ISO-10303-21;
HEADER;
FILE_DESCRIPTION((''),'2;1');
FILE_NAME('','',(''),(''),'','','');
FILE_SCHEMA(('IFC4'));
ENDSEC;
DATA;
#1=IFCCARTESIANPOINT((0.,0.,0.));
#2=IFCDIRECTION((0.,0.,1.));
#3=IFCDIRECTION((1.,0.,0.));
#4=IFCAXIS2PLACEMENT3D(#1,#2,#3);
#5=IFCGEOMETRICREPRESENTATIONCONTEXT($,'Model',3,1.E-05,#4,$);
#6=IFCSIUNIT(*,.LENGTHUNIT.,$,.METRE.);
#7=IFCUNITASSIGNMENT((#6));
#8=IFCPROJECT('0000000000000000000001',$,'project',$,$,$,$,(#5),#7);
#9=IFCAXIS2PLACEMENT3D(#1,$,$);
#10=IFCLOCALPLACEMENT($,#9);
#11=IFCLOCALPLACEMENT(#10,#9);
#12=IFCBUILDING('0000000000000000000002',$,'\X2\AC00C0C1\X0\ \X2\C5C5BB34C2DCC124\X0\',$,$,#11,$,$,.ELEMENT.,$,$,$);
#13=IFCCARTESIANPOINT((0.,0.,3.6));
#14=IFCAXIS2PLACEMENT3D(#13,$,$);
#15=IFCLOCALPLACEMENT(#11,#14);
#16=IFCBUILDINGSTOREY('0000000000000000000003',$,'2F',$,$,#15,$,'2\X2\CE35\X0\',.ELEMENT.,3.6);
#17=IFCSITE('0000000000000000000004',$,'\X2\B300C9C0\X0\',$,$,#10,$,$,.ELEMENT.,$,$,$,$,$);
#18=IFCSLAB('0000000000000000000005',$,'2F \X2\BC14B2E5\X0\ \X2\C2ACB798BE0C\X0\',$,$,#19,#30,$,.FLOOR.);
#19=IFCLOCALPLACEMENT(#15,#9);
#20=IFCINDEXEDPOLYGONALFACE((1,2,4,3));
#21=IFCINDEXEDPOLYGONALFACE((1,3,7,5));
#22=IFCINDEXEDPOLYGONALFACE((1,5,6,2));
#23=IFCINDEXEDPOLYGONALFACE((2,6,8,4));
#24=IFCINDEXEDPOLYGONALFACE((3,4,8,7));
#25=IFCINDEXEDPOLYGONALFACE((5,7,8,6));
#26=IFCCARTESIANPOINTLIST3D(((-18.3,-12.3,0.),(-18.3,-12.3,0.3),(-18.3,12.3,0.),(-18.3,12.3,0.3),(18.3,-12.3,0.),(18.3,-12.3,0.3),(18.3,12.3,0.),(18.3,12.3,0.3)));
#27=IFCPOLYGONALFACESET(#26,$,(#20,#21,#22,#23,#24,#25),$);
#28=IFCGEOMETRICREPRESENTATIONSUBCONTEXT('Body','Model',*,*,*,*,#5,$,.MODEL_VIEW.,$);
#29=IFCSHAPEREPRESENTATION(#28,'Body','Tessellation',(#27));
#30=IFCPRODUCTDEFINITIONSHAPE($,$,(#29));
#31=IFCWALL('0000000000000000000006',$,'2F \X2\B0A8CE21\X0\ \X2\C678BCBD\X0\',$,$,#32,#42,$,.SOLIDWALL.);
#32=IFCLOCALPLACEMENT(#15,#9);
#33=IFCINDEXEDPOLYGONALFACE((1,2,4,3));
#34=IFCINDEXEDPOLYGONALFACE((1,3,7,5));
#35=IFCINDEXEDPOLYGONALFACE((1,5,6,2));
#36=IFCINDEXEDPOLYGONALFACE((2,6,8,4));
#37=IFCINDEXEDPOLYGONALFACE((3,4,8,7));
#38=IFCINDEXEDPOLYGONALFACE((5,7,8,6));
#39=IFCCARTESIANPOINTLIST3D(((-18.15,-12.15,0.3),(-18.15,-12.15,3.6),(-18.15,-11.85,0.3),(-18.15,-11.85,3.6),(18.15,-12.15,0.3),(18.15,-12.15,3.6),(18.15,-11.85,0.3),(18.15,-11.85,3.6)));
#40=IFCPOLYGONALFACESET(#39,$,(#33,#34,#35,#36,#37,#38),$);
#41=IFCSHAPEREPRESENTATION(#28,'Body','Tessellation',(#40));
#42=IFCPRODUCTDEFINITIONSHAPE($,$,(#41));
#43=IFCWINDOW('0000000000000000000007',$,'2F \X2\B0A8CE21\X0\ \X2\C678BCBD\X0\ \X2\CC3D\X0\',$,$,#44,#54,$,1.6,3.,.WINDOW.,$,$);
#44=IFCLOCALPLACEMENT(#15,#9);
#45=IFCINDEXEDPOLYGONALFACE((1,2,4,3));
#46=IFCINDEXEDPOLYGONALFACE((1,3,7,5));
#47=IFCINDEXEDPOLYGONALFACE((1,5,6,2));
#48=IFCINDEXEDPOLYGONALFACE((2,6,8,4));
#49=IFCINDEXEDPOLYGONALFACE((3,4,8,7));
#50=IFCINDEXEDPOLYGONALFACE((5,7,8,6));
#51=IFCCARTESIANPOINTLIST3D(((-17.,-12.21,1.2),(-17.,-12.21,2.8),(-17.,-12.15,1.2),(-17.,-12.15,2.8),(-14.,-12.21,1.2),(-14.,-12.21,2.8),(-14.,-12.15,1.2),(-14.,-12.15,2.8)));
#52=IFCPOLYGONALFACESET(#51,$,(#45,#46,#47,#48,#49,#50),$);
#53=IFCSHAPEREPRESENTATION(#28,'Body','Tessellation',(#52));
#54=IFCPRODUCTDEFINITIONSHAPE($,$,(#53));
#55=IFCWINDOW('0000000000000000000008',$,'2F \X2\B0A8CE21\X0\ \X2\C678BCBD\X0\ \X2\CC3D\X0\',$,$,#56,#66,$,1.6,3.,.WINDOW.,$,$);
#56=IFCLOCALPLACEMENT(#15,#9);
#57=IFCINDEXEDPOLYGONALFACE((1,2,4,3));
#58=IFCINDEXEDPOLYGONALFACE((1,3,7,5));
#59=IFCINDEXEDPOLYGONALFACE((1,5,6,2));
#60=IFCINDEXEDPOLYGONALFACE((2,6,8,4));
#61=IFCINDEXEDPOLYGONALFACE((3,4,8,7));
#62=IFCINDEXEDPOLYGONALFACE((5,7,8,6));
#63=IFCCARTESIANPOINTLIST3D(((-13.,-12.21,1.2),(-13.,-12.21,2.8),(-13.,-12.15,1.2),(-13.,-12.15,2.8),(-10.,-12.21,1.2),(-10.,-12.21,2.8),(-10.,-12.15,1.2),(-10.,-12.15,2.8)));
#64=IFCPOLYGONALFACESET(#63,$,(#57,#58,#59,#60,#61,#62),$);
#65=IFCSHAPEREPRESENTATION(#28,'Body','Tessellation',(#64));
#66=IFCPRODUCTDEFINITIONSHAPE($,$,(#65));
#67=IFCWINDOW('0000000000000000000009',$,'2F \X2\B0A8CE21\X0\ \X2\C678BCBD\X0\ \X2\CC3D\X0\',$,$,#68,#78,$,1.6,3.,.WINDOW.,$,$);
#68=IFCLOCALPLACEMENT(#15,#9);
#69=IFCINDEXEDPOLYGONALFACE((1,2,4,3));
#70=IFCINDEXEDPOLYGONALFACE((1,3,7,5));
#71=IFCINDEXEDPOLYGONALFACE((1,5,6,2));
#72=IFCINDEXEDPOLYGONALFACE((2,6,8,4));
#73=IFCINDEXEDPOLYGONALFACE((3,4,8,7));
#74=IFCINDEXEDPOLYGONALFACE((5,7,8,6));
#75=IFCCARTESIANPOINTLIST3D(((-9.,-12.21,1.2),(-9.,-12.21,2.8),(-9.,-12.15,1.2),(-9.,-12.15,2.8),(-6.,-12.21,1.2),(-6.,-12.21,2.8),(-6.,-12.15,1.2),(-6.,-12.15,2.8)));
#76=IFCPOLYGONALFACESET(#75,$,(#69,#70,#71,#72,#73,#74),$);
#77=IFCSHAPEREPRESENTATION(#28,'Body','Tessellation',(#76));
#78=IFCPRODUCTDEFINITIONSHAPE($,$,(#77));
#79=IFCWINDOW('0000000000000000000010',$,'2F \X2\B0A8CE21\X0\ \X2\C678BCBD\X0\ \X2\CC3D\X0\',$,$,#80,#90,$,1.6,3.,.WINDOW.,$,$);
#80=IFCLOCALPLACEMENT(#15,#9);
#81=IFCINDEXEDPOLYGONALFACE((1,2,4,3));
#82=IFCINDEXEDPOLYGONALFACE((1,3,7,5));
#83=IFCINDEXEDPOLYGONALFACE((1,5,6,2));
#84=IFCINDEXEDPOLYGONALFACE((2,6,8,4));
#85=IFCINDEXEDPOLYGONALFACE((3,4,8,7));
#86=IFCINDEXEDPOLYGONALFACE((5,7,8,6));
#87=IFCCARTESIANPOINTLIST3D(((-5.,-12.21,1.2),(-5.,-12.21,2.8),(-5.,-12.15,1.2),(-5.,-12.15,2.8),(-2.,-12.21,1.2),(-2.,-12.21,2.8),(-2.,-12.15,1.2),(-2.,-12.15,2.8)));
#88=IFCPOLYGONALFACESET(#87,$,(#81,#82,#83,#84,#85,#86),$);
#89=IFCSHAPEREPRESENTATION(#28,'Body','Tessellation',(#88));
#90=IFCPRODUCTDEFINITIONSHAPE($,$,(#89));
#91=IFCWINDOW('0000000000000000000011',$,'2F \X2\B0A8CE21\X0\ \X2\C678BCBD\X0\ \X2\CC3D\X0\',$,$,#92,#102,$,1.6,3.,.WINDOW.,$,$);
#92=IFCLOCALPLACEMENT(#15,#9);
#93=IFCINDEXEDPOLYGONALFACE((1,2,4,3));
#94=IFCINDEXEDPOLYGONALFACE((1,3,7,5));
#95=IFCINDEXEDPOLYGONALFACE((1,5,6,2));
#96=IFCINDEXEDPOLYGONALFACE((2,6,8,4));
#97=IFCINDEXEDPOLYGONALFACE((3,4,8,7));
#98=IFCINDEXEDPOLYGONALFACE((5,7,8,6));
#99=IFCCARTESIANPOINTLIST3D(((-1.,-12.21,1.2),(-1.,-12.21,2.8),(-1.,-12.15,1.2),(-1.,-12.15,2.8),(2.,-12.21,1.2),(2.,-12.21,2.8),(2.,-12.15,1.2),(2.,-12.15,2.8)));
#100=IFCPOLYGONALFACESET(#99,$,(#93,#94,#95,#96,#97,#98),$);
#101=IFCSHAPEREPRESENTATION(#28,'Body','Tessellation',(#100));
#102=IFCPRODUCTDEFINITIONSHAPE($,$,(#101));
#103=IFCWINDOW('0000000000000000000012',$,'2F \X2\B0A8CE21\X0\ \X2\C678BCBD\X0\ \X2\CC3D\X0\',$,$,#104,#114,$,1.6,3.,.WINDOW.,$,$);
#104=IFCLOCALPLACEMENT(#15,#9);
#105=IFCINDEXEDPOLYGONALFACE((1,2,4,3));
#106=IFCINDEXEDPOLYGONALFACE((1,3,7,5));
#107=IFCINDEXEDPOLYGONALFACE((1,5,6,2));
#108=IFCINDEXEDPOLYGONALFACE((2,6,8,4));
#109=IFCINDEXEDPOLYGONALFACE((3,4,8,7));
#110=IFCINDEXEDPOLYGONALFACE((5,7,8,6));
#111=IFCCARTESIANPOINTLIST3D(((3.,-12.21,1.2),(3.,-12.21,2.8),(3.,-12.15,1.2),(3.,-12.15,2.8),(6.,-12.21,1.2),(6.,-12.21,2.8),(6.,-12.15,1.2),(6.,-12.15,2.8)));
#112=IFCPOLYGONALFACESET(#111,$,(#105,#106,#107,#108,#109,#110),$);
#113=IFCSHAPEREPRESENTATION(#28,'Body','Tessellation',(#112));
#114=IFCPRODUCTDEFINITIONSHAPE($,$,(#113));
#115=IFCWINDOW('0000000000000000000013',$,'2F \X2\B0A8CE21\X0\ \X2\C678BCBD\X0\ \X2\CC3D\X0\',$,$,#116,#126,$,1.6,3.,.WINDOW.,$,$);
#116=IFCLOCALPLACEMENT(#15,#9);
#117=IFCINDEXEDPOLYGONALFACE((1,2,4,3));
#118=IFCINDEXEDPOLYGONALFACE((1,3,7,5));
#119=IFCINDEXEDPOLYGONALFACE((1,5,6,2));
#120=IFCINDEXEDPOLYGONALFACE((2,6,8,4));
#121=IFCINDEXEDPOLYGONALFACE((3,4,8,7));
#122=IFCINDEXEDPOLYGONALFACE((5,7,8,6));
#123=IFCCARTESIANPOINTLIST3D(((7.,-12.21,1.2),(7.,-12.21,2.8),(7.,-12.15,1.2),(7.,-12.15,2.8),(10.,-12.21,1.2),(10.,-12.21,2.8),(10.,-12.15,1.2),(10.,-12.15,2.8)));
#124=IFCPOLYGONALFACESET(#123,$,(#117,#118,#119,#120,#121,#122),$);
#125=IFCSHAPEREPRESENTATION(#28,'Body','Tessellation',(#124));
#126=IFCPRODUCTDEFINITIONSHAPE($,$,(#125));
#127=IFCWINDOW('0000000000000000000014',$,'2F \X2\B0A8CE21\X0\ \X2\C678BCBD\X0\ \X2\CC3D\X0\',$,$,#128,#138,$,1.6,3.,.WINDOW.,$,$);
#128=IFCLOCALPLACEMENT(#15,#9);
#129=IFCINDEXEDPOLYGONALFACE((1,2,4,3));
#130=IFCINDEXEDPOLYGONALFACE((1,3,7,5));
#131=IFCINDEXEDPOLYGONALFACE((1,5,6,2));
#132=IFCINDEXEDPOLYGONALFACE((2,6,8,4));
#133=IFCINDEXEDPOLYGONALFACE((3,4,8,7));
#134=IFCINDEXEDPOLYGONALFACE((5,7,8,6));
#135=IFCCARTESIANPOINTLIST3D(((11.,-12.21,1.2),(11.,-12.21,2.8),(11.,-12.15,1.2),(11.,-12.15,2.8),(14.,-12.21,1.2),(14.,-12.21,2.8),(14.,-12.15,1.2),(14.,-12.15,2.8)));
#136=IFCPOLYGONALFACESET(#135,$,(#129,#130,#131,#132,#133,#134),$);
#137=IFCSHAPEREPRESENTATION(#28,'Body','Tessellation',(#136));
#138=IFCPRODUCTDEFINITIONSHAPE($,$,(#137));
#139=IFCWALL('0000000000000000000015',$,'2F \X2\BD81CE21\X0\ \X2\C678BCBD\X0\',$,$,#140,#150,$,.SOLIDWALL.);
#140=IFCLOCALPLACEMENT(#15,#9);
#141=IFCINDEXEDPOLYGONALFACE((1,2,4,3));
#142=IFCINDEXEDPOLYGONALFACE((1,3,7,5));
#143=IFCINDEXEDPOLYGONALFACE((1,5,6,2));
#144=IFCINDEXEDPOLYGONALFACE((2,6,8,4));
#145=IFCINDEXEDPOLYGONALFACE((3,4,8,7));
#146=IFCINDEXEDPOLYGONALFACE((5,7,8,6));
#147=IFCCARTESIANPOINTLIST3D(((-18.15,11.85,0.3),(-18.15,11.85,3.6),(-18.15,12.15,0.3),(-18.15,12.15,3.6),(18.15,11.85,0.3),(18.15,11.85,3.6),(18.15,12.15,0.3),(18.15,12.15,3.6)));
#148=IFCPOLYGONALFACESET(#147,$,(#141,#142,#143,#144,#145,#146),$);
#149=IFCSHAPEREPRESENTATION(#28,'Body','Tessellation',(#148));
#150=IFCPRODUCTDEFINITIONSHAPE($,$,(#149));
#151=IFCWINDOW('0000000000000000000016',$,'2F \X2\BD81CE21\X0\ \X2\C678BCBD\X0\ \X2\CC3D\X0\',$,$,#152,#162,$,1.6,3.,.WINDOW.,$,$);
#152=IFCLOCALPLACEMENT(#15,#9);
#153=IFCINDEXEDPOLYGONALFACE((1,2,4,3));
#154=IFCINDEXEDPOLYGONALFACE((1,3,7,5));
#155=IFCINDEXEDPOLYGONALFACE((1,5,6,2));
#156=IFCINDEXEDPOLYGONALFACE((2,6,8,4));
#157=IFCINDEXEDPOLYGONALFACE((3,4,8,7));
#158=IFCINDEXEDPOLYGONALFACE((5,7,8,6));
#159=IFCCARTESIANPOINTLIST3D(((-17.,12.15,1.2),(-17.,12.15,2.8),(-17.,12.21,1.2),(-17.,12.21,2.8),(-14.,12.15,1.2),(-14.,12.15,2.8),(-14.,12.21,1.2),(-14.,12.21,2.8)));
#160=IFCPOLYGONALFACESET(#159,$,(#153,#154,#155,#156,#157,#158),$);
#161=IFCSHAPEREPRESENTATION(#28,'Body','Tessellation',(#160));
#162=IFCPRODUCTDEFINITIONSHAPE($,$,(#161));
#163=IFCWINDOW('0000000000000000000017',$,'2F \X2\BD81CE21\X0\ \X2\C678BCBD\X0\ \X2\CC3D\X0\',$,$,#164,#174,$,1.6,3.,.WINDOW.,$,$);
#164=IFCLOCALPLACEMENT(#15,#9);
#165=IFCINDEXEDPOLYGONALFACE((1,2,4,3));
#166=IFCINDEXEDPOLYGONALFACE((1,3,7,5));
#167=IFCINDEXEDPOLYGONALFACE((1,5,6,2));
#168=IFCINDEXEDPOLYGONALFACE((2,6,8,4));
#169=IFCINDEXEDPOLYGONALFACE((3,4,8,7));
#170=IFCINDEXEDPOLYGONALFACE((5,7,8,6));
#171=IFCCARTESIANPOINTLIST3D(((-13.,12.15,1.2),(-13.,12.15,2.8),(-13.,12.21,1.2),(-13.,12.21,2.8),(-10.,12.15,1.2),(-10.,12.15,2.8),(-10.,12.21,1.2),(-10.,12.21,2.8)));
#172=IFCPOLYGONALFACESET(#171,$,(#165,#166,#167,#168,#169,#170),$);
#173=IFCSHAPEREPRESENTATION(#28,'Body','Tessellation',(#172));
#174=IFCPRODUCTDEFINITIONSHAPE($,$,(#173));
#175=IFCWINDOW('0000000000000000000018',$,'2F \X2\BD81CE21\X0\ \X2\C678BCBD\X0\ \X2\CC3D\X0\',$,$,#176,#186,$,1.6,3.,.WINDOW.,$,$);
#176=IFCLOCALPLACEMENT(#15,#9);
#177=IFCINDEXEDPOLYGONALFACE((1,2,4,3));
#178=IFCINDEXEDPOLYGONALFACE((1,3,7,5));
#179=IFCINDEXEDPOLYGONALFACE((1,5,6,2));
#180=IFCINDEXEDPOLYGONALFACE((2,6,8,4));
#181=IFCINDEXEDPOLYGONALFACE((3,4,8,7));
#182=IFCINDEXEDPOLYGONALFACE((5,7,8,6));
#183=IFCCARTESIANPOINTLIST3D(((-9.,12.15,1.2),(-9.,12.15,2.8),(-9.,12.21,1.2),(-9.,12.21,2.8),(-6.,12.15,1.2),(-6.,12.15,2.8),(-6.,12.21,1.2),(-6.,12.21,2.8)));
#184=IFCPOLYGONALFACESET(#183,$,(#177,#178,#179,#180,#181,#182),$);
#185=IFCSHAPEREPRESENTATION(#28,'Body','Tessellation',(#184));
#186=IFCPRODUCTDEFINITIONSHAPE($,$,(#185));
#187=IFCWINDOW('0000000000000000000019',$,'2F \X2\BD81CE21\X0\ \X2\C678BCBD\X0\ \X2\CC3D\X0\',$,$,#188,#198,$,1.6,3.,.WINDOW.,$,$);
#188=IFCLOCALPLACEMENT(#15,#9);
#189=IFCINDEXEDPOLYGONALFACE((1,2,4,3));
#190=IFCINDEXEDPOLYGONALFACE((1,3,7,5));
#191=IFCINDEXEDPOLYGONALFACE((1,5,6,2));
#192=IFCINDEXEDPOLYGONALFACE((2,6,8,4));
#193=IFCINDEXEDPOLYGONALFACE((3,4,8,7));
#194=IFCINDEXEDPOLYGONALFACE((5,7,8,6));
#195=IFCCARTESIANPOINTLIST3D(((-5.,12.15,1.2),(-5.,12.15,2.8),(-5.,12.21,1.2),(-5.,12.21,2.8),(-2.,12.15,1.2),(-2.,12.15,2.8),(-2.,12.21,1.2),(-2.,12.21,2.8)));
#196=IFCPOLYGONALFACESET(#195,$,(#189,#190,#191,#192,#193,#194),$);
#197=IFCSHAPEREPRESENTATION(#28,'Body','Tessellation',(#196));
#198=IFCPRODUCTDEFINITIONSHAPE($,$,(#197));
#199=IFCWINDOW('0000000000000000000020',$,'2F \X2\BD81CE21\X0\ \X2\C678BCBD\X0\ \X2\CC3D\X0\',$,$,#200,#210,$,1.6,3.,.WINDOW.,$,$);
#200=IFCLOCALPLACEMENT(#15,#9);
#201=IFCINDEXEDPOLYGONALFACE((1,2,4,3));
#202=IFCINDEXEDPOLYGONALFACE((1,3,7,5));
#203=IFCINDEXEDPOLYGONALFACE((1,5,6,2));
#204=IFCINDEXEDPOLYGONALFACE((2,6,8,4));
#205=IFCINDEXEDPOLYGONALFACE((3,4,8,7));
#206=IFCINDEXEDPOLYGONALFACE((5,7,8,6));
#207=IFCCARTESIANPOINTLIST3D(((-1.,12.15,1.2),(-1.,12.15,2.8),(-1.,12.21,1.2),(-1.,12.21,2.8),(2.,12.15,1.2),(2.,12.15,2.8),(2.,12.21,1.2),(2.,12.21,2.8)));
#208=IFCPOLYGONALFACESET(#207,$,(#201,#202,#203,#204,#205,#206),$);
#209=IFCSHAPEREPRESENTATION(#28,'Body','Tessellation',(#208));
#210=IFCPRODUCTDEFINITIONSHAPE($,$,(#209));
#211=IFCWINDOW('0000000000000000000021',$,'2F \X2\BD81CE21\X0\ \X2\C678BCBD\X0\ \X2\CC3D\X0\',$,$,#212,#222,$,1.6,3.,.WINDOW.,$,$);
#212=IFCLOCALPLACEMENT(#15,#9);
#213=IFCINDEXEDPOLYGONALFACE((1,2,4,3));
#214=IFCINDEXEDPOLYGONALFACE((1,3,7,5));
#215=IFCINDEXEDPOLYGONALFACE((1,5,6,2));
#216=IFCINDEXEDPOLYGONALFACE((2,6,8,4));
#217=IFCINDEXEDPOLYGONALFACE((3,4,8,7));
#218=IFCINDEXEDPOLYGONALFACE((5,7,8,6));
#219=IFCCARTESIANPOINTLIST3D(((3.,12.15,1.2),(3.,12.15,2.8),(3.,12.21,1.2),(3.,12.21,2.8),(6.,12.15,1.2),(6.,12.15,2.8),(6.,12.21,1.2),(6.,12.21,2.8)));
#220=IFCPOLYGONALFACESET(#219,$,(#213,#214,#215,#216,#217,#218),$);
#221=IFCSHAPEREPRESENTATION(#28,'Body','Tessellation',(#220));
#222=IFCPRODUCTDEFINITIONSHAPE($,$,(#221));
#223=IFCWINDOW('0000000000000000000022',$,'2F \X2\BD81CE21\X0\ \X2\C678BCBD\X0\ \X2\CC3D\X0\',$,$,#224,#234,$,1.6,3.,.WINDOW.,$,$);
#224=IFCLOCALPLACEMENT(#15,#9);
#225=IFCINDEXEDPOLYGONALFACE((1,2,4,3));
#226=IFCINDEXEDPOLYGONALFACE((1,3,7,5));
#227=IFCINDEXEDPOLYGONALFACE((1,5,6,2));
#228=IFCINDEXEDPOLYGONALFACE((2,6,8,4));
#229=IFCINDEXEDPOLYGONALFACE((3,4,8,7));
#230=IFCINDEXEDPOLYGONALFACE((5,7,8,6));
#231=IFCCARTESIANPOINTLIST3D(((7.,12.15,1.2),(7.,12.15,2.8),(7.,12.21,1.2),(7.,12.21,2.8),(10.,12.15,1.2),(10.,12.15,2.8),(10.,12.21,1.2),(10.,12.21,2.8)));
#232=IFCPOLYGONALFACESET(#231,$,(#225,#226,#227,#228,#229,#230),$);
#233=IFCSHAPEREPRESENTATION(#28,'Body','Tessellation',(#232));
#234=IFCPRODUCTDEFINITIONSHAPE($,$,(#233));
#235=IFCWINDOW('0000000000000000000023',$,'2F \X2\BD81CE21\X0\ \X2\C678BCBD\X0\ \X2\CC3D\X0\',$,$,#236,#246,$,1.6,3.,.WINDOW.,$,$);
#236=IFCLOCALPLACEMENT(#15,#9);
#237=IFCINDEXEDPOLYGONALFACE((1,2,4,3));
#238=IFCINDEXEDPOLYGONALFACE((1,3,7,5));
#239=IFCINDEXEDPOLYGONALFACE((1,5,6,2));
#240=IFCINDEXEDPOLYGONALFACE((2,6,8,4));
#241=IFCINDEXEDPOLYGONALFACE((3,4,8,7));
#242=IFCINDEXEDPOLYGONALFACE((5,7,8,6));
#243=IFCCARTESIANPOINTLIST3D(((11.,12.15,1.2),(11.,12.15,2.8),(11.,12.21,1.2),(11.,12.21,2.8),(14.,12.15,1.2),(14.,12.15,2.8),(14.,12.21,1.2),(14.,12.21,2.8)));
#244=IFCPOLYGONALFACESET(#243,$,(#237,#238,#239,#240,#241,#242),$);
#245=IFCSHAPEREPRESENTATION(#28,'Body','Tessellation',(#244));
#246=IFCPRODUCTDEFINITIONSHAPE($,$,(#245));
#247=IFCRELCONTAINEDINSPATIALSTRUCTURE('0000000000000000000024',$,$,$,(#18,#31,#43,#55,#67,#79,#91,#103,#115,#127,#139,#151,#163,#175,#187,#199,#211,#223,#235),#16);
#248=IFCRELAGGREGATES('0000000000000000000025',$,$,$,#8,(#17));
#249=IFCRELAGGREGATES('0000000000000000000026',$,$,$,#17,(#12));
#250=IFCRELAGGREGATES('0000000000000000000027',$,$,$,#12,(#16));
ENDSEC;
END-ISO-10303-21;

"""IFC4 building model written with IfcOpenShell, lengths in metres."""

from ifc_helpers import new_model, si_unit, frame, origin, origin_with_axes, origin_2d, place, context, subcontext, project, spatial, rectangle, extrude, element, save


model = new_model("IFC4")

# Units and contexts
model_context = context("Model", 3, precision=1e-05, world=origin_with_axes())
body_context = subcontext(model_context, "Body", "Model", "MODEL_VIEW")
ifc_project = project(units=[si_unit("LENGTHUNIT", "METRE")], contexts=[model_context])

# Site, building, storey
site_placement = place(None, origin())
site = spatial("IfcSite", under=ifc_project, at=site_placement, Name="대지", CompositionType="ELEMENT")
building_placement = place(site_placement, origin())
building = spatial("IfcBuilding", under=site, at=building_placement, Name="가상 업무시설", CompositionType="ELEMENT")
storey_placement = place(building_placement, frame((0.0, 0.0, 3.6)))
storey = spatial("IfcBuildingStorey", under=building, at=storey_placement, Name="2F", LongName="2층", CompositionType="ELEMENT", Elevation=3.6)

# Slab
slab_placement = place(storey_placement, origin())
element("IfcSlab", 1, at=slab_placement, inside=storey, Name="2F 바닥 슬래브", PredefinedType="FLOOR", context=body_context, shape_type="SweptSolid", body=[
    extrude(rectangle(XDim=36.6, YDim=24.6, at=origin_2d()), origin_with_axes(), (0.0, 0.0, 1.0), 0.3),
])

# Wall
wall_1_placement = place(storey_placement, frame((0.0, -12.0, 0.3)))
element("IfcWall", 2, at=wall_1_placement, inside=storey, Name="2F 남측 외벽", PredefinedType="SOLIDWALL", context=body_context, shape_type="SweptSolid", body=[
    extrude(rectangle(XDim=36.3, YDim=0.3, at=origin_2d()), origin_with_axes(), (0.0, 0.0, 1.0), 3.3),
])

# Windows
for number, where, name in (
    (3, (-15.5, -12.18, 1.2), "2F 남측 외벽 창"),
    (4, (-11.5, -12.18, 1.2), "2F 남측 외벽 창"),
    (5, (-7.5, -12.18, 1.2), "2F 남측 외벽 창"),
    (6, (-3.5, -12.18, 1.2), "2F 남측 외벽 창"),
    (7, (0.5, -12.18, 1.2), "2F 남측 외벽 창"),
    (8, (4.5, -12.18, 1.2), "2F 남측 외벽 창"),
    (9, (8.5, -12.18, 1.2), "2F 남측 외벽 창"),
    (10, (12.5, -12.18, 1.2), "2F 남측 외벽 창"),
):
    element("IfcWindow", number, at=place(storey_placement, frame(where)), inside=storey, Name=name, OverallHeight=1.6, OverallWidth=3.0, PredefinedType="WINDOW", context=body_context, shape_type="SweptSolid", body=[
        extrude(rectangle(XDim=3.0, YDim=0.06, at=origin_2d()), origin_with_axes(), (0.0, 0.0, 1.0), 1.6),
    ])

# Wall
wall_2_placement = place(storey_placement, frame((0.0, 12.0, 0.3)))
element("IfcWall", 11, at=wall_2_placement, inside=storey, Name="2F 북측 외벽", PredefinedType="SOLIDWALL", context=body_context, shape_type="SweptSolid", body=[
    extrude(rectangle(XDim=36.3, YDim=0.3, at=origin_2d()), origin_with_axes(), (0.0, 0.0, 1.0), 3.3),
])

# Windows
for number, where, name in (
    (12, (-15.5, 12.18, 1.2), "2F 북측 외벽 창"),
    (13, (-11.5, 12.18, 1.2), "2F 북측 외벽 창"),
    (14, (-7.5, 12.18, 1.2), "2F 북측 외벽 창"),
    (15, (-3.5, 12.18, 1.2), "2F 북측 외벽 창"),
    (16, (0.5, 12.18, 1.2), "2F 북측 외벽 창"),
    (17, (4.5, 12.18, 1.2), "2F 북측 외벽 창"),
    (18, (8.5, 12.18, 1.2), "2F 북측 외벽 창"),
    (19, (12.5, 12.18, 1.2), "2F 북측 외벽 창"),
):
    element("IfcWindow", number, at=place(storey_placement, frame(where)), inside=storey, Name=name, OverallHeight=1.6, OverallWidth=3.0, PredefinedType="WINDOW", context=body_context, shape_type="SweptSolid", body=[
        extrude(rectangle(XDim=3.0, YDim=0.06, at=origin_2d()), origin_with_axes(), (0.0, 0.0, 1.0), 1.6),
    ])

save(model, "model.ifc")
